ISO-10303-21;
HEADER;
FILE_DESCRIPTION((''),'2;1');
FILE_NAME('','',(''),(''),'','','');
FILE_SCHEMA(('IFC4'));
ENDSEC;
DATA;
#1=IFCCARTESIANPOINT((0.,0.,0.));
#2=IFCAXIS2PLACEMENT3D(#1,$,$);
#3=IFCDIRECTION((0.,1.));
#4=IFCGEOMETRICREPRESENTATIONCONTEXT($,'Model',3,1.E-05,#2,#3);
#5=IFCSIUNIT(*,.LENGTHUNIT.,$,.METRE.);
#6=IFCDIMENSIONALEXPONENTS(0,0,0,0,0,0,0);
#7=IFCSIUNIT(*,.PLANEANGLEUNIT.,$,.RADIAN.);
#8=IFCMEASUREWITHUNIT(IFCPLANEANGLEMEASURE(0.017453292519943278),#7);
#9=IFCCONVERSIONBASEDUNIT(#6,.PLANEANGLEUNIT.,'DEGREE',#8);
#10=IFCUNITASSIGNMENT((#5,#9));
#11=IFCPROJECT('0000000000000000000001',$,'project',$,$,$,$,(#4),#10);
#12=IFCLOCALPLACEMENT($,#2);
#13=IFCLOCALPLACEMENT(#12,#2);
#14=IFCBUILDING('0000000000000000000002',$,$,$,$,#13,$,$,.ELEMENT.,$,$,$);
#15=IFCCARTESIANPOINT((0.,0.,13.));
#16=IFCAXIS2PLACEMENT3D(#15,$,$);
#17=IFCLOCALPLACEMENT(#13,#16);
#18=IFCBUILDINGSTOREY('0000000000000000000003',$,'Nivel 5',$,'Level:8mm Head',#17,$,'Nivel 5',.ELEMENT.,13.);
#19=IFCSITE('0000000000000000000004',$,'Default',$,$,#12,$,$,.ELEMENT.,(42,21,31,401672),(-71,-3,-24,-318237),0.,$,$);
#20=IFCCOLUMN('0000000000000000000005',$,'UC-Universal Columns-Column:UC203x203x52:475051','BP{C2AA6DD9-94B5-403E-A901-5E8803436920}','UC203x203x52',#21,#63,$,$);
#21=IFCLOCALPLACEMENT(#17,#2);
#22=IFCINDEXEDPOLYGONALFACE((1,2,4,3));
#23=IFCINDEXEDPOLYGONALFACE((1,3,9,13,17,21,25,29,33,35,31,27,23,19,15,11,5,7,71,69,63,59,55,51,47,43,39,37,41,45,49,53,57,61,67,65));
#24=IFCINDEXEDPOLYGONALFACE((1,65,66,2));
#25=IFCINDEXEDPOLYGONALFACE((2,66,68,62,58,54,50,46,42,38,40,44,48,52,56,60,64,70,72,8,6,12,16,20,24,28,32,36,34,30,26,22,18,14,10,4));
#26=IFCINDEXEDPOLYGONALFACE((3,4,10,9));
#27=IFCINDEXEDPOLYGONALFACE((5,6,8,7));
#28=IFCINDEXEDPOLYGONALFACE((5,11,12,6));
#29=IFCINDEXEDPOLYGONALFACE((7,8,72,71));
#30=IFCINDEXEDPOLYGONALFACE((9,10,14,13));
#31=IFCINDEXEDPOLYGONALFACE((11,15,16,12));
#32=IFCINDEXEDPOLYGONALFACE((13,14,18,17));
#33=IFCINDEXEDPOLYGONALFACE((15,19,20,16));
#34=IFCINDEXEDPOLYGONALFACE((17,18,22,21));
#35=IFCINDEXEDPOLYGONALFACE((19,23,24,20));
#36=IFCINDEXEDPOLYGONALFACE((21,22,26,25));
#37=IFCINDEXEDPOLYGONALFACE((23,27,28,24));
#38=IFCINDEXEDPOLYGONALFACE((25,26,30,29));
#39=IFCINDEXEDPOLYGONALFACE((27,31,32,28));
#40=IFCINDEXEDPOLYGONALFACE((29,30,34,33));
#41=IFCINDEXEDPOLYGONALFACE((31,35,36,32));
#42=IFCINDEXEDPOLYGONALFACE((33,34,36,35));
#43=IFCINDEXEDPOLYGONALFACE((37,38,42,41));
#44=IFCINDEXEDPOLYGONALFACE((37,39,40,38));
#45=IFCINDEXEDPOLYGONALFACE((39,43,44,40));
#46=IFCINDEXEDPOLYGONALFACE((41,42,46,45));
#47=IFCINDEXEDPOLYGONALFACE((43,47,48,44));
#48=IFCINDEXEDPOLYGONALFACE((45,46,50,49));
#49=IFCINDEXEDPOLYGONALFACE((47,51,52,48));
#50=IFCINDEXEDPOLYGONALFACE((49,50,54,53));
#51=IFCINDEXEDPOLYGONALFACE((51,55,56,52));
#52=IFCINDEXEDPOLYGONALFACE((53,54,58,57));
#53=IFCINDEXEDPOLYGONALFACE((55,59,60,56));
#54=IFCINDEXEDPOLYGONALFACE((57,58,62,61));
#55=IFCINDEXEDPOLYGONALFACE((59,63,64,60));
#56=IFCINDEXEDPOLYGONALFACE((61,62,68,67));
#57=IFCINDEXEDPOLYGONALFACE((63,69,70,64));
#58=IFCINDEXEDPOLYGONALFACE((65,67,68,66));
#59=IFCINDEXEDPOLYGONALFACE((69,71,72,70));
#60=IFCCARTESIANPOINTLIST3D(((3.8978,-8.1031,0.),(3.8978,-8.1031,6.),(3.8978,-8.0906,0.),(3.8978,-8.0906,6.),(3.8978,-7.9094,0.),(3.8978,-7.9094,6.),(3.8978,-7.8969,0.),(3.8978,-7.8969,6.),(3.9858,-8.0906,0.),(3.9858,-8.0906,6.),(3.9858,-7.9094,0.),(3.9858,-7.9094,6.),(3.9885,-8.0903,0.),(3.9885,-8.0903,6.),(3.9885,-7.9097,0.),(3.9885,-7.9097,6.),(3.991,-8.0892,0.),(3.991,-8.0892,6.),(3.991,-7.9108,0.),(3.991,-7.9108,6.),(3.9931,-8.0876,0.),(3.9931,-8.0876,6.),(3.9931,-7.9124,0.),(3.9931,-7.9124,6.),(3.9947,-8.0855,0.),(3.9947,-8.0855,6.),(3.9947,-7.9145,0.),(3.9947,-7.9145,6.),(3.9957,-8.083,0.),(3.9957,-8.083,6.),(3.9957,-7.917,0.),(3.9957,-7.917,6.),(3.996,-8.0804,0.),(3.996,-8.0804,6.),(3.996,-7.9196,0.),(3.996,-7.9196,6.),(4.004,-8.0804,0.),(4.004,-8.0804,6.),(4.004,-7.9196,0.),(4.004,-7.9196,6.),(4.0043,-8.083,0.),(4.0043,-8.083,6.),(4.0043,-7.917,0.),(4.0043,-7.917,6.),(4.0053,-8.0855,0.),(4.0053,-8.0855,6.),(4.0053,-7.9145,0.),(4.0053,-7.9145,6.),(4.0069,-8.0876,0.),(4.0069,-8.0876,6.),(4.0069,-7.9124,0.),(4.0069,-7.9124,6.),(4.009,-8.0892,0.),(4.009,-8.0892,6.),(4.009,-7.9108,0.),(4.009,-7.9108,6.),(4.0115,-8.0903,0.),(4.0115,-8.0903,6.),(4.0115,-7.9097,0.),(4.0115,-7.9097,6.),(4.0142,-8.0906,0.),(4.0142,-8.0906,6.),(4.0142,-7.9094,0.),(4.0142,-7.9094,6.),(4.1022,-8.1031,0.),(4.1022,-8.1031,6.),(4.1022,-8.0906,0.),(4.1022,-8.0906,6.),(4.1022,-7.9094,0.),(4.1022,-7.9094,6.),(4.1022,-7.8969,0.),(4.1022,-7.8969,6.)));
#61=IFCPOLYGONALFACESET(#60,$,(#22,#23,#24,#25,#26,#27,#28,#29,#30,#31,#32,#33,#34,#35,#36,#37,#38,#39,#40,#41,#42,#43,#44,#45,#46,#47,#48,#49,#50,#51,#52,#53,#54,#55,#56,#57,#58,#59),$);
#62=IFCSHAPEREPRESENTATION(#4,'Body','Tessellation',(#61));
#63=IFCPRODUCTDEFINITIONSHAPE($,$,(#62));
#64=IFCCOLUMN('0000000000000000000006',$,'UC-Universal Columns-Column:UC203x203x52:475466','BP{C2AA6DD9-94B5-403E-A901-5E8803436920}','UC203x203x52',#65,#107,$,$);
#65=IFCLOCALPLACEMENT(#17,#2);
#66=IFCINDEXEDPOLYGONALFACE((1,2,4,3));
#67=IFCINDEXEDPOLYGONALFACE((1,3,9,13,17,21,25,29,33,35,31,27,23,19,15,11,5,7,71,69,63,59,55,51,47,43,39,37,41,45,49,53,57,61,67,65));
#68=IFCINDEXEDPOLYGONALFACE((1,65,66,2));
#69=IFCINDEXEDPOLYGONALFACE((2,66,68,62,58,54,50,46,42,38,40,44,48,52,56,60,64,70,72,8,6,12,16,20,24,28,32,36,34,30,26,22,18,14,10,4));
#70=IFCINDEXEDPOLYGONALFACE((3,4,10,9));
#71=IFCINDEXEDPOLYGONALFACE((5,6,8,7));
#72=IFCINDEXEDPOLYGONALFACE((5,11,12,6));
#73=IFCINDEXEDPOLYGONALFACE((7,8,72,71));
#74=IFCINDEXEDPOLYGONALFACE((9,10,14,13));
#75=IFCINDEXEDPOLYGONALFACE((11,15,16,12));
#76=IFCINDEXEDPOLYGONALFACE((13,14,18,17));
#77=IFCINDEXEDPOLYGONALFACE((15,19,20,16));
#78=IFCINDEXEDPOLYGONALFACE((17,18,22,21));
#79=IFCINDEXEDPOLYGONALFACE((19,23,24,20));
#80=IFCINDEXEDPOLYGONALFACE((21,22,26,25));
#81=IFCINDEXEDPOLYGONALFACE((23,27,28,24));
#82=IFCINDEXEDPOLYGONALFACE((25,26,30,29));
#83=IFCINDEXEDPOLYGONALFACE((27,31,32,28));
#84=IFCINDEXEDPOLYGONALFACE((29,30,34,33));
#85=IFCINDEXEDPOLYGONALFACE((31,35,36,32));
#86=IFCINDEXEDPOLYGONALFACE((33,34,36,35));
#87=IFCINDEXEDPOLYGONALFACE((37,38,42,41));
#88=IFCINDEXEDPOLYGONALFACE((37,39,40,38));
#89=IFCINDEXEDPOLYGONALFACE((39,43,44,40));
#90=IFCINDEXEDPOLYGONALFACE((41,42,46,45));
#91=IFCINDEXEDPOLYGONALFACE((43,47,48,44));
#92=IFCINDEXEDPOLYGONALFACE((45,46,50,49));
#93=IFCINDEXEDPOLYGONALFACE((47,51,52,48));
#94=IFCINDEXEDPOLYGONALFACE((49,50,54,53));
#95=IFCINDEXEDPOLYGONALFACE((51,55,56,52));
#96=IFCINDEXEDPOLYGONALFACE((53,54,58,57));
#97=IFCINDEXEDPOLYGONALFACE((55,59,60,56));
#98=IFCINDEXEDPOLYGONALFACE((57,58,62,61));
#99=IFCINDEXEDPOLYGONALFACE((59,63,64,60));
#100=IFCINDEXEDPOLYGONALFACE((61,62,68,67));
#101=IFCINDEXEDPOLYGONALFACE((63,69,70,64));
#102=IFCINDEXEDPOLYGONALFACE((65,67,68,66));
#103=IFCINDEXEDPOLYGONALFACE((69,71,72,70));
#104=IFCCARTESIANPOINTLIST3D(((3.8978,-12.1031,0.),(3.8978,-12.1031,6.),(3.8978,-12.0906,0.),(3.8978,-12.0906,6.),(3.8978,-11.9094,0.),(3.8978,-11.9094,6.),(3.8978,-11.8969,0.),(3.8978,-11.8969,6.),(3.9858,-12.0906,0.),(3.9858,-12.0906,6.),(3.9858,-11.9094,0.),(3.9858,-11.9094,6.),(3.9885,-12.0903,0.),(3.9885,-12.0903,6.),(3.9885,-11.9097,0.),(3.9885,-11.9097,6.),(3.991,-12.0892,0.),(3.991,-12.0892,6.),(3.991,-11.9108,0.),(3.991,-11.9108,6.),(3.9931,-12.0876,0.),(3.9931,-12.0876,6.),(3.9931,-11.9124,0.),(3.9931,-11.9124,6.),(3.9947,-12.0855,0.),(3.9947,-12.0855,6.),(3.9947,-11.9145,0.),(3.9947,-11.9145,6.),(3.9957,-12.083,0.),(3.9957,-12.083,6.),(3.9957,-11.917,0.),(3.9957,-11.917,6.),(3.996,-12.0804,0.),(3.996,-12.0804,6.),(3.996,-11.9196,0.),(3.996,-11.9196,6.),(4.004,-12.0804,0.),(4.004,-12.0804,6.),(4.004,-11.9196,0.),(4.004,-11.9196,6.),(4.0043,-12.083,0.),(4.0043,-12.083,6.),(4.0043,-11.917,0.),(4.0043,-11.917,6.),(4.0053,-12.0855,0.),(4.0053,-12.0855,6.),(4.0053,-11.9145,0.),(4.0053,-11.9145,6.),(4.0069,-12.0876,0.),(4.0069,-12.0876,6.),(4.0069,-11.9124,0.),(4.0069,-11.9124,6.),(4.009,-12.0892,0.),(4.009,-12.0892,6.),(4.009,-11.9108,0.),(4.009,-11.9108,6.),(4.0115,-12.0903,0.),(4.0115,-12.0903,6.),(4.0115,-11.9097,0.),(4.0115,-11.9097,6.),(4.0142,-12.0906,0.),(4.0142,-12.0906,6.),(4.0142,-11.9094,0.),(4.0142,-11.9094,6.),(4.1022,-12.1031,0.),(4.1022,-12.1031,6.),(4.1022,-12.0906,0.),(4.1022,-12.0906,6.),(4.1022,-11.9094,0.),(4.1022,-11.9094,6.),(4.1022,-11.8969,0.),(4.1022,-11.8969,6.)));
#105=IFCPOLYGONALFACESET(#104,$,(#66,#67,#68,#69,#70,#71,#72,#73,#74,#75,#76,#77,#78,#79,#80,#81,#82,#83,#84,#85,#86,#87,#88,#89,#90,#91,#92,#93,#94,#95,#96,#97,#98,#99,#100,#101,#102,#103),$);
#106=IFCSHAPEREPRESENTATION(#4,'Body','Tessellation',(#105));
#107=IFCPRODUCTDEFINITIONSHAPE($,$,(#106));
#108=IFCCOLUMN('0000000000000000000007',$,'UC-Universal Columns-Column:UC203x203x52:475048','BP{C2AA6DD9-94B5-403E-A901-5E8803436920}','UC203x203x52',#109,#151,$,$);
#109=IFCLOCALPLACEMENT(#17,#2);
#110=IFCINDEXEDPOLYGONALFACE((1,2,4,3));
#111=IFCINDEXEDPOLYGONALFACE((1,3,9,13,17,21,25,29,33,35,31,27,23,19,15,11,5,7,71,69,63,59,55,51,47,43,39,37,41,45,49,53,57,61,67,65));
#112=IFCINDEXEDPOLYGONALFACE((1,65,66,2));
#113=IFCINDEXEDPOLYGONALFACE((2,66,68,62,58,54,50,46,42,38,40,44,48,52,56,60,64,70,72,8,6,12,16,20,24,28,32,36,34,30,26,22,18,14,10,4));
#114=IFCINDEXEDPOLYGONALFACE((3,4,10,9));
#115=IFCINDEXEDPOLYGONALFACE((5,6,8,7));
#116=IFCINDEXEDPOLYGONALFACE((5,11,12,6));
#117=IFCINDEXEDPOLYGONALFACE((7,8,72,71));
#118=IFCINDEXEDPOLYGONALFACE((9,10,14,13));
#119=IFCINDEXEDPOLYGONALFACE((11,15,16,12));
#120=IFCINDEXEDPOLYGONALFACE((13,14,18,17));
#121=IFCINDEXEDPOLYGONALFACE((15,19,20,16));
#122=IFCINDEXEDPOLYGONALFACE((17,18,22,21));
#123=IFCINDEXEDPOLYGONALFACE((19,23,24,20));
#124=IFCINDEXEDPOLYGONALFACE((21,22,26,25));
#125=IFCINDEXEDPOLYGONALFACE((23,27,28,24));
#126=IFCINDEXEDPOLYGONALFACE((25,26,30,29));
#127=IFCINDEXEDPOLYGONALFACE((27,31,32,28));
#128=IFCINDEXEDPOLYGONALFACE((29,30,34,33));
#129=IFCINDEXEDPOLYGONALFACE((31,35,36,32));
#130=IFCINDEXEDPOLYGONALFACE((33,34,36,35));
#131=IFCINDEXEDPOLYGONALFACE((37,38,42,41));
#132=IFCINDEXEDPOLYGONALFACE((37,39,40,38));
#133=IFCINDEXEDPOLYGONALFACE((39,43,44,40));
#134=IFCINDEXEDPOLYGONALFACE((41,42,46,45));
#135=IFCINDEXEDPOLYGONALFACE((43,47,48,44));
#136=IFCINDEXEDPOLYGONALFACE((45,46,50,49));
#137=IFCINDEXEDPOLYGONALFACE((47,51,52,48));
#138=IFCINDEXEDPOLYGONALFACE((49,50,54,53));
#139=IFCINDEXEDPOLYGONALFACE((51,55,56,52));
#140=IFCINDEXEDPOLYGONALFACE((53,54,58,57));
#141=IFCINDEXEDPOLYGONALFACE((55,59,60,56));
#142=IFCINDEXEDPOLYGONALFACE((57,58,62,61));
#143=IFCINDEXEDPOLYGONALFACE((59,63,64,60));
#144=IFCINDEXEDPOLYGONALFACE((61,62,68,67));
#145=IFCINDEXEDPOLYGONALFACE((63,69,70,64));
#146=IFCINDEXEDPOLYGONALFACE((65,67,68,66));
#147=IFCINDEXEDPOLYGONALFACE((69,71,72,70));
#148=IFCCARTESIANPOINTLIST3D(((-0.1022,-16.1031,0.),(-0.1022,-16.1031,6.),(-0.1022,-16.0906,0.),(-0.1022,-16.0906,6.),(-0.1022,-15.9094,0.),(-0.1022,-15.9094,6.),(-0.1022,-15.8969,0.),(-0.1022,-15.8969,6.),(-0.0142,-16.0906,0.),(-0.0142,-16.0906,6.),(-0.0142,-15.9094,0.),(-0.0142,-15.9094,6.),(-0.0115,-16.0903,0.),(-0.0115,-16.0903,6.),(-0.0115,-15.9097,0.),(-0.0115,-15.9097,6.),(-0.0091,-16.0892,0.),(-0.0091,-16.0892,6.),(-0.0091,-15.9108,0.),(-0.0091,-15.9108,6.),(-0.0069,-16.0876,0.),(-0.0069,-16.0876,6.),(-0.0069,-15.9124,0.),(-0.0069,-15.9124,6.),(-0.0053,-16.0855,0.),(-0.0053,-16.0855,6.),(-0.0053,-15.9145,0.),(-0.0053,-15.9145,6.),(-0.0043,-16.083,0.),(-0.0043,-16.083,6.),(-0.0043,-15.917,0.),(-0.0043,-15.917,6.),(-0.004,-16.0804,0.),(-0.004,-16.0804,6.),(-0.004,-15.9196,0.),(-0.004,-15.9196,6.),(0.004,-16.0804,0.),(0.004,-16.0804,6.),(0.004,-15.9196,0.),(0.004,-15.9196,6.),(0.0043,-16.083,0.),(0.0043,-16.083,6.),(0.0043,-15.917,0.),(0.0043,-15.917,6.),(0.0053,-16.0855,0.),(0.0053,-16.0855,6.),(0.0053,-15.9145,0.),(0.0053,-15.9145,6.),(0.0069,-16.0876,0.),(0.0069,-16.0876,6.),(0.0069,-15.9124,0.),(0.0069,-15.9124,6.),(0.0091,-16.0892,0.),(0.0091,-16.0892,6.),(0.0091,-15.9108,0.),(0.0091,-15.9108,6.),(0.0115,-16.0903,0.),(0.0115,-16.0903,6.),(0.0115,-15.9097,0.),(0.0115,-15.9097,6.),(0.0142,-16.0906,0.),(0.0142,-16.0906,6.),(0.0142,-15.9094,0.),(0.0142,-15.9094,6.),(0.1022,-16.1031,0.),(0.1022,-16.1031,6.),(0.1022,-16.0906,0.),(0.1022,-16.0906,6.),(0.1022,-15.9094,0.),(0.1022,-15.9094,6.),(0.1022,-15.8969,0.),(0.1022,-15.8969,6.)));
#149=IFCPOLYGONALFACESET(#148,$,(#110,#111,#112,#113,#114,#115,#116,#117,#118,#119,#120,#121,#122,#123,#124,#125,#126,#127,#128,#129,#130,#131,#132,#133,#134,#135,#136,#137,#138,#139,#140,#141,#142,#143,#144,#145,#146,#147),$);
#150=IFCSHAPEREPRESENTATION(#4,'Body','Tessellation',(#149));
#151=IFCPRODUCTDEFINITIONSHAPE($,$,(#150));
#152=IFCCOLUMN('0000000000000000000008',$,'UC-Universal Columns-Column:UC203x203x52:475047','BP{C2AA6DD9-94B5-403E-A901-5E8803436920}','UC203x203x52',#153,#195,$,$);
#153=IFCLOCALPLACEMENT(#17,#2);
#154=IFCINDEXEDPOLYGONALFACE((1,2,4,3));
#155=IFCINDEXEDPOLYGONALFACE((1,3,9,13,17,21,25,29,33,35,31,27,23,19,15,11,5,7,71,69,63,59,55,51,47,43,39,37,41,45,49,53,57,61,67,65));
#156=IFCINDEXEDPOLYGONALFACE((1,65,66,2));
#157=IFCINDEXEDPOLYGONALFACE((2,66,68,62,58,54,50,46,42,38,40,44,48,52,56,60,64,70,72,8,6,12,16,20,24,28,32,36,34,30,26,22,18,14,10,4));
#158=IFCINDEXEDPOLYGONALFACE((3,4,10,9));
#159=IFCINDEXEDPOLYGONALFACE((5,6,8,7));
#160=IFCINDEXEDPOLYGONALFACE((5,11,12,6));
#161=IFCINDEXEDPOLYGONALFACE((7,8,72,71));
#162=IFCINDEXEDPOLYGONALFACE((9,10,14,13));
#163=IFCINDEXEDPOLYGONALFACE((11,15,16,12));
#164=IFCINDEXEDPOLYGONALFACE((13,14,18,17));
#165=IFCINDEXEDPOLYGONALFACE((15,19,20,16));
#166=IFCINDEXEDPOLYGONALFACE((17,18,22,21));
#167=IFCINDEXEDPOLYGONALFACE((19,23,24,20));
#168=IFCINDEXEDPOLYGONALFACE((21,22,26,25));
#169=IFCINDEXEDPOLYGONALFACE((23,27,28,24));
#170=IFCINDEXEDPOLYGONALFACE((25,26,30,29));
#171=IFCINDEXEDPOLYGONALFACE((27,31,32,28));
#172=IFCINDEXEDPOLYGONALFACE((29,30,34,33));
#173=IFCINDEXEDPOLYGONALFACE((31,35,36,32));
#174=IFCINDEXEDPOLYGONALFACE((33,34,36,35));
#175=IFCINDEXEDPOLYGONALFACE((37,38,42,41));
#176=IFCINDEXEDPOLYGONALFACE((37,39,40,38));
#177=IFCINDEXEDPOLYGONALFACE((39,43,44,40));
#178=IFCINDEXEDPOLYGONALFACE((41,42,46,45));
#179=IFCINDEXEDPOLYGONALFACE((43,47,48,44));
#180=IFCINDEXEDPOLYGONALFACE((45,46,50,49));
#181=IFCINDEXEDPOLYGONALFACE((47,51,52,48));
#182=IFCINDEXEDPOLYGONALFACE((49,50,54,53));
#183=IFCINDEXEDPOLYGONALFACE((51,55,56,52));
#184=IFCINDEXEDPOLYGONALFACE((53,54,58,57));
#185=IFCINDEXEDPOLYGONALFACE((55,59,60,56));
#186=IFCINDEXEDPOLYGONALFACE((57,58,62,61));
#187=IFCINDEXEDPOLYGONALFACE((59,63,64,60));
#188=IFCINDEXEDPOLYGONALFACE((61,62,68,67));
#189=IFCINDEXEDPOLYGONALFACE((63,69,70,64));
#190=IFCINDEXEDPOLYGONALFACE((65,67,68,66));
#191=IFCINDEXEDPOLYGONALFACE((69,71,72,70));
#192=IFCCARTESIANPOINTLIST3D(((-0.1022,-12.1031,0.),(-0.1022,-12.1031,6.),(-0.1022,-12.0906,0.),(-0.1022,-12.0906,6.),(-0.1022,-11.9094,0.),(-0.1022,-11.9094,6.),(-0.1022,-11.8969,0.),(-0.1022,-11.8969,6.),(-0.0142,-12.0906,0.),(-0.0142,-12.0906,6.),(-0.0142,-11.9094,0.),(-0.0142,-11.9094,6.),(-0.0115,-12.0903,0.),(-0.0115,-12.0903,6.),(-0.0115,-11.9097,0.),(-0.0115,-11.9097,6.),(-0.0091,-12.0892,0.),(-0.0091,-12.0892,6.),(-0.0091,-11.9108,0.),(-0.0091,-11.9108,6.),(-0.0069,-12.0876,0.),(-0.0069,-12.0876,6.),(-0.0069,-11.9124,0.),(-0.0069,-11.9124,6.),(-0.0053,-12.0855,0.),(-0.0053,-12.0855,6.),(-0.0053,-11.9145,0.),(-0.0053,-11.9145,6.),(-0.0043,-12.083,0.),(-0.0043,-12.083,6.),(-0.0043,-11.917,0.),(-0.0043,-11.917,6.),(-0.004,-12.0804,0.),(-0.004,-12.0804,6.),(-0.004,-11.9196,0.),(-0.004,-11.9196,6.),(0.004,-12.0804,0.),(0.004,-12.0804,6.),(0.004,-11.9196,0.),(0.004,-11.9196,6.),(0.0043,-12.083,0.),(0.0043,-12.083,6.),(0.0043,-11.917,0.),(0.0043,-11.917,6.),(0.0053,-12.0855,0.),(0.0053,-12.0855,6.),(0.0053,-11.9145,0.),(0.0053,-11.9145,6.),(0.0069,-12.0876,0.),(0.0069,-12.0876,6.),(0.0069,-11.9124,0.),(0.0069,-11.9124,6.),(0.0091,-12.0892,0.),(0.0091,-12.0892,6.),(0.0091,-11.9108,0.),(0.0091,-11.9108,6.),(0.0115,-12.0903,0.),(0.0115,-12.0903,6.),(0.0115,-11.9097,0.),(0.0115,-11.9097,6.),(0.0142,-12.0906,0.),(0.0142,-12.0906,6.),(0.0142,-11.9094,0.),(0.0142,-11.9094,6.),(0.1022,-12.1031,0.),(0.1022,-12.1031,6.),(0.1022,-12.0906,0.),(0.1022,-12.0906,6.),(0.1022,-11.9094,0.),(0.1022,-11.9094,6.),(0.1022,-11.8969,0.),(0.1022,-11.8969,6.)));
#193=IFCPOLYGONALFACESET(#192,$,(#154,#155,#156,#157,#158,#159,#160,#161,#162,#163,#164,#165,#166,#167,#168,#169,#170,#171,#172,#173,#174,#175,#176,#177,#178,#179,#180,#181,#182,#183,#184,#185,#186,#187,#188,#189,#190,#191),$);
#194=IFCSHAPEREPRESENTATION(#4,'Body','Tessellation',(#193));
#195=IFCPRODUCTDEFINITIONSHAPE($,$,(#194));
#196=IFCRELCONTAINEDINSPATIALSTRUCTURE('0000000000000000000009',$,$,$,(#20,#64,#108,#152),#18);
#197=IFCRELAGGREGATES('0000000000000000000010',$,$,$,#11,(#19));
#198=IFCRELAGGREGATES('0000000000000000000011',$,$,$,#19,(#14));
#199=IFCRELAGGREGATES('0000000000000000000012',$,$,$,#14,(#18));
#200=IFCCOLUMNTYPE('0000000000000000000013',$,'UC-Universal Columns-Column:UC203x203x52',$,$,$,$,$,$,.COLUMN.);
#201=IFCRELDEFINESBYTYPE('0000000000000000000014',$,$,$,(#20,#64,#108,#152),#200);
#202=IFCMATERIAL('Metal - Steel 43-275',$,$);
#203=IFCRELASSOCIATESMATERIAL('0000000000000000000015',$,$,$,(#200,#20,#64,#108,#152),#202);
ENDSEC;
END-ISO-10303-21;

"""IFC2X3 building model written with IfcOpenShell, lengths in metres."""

from ifc_helpers import new_model, entity, si_unit, converted_unit, direction, frame, origin, origin_2d, place, context, project, spatial, i_section, extrude, material, type_object, element, save


model = new_model("IFC2X3")

# Units and contexts
model_context = context("Model", 3, precision=1e-05, world=origin(), true_north=direction((0.0, 1.0)))
ifc_project = project(units=[si_unit("LENGTHUNIT", "METRE"), converted_unit("PLANEANGLEUNIT", "DEGREE", entity("IfcPlaneAngleMeasure", 0.017453292519943278), si_unit("PLANEANGLEUNIT", "RADIAN"), dimensions=[0, 0, 0, 0, 0, 0, 0])], contexts=[model_context])

# Site, building, storey
site_placement = place(None, origin())
site = spatial("IfcSite", under=ifc_project, at=site_placement, Name="Default", CompositionType="ELEMENT", RefLatitude=(42, 21, 31, 401672), RefLongitude=(-71, -3, -24, -318237), RefElevation=0.0)
building_placement = place(site_placement, origin())
building = spatial("IfcBuilding", under=site, at=building_placement, CompositionType="ELEMENT")
storey_placement = place(building_placement, frame((0.0, 0.0, 13.0)))
storey = spatial("IfcBuildingStorey", under=building, at=storey_placement, Name="Nivel 5", ObjectType="Level:8mm Head", LongName="Nivel 5", CompositionType="ELEMENT", Elevation=13.0)

# Columns
ifc_material_1 = material(Name="Metal - Steel 43-275")
column_type_1 = type_object("IfcColumnType", Name="UC-Universal Columns-Column:UC203x203x52", PredefinedType="COLUMN", material=ifc_material_1)
for number, where, name in (
    (1, (4.0, -8.0, 6.0), "UC-Universal Columns-Column:UC203x203x52:475051"),
    (2, (4.0, -12.0, 6.0), "UC-Universal Columns-Column:UC203x203x52:475466"),
    (3, (0.0, -16.0, 6.0), "UC-Universal Columns-Column:UC203x203x52:475048"),
    (4, (0.0, -12.0, 6.0), "UC-Universal Columns-Column:UC203x203x52:475047"),
):
    element("IfcColumn", number, at=place(storey_placement, frame(where)), inside=storey, type_object=column_type_1, material=ifc_material_1, Name=name, Description="BP{C2AA6DD9-94B5-403E-A901-5E8803436920}", ObjectType="UC203x203x52", context=model_context, shape_type="SweptSolid", body=[
        extrude(i_section(OverallWidth=0.2043, OverallDepth=0.2062, WebThickness=0.0079, FlangeThickness=0.0125, FilletRadius=0.0102, at=origin_2d()), origin(), (0.0, 0.0, -1.0), 6.0),
    ])

save(model, "model.ifc")
